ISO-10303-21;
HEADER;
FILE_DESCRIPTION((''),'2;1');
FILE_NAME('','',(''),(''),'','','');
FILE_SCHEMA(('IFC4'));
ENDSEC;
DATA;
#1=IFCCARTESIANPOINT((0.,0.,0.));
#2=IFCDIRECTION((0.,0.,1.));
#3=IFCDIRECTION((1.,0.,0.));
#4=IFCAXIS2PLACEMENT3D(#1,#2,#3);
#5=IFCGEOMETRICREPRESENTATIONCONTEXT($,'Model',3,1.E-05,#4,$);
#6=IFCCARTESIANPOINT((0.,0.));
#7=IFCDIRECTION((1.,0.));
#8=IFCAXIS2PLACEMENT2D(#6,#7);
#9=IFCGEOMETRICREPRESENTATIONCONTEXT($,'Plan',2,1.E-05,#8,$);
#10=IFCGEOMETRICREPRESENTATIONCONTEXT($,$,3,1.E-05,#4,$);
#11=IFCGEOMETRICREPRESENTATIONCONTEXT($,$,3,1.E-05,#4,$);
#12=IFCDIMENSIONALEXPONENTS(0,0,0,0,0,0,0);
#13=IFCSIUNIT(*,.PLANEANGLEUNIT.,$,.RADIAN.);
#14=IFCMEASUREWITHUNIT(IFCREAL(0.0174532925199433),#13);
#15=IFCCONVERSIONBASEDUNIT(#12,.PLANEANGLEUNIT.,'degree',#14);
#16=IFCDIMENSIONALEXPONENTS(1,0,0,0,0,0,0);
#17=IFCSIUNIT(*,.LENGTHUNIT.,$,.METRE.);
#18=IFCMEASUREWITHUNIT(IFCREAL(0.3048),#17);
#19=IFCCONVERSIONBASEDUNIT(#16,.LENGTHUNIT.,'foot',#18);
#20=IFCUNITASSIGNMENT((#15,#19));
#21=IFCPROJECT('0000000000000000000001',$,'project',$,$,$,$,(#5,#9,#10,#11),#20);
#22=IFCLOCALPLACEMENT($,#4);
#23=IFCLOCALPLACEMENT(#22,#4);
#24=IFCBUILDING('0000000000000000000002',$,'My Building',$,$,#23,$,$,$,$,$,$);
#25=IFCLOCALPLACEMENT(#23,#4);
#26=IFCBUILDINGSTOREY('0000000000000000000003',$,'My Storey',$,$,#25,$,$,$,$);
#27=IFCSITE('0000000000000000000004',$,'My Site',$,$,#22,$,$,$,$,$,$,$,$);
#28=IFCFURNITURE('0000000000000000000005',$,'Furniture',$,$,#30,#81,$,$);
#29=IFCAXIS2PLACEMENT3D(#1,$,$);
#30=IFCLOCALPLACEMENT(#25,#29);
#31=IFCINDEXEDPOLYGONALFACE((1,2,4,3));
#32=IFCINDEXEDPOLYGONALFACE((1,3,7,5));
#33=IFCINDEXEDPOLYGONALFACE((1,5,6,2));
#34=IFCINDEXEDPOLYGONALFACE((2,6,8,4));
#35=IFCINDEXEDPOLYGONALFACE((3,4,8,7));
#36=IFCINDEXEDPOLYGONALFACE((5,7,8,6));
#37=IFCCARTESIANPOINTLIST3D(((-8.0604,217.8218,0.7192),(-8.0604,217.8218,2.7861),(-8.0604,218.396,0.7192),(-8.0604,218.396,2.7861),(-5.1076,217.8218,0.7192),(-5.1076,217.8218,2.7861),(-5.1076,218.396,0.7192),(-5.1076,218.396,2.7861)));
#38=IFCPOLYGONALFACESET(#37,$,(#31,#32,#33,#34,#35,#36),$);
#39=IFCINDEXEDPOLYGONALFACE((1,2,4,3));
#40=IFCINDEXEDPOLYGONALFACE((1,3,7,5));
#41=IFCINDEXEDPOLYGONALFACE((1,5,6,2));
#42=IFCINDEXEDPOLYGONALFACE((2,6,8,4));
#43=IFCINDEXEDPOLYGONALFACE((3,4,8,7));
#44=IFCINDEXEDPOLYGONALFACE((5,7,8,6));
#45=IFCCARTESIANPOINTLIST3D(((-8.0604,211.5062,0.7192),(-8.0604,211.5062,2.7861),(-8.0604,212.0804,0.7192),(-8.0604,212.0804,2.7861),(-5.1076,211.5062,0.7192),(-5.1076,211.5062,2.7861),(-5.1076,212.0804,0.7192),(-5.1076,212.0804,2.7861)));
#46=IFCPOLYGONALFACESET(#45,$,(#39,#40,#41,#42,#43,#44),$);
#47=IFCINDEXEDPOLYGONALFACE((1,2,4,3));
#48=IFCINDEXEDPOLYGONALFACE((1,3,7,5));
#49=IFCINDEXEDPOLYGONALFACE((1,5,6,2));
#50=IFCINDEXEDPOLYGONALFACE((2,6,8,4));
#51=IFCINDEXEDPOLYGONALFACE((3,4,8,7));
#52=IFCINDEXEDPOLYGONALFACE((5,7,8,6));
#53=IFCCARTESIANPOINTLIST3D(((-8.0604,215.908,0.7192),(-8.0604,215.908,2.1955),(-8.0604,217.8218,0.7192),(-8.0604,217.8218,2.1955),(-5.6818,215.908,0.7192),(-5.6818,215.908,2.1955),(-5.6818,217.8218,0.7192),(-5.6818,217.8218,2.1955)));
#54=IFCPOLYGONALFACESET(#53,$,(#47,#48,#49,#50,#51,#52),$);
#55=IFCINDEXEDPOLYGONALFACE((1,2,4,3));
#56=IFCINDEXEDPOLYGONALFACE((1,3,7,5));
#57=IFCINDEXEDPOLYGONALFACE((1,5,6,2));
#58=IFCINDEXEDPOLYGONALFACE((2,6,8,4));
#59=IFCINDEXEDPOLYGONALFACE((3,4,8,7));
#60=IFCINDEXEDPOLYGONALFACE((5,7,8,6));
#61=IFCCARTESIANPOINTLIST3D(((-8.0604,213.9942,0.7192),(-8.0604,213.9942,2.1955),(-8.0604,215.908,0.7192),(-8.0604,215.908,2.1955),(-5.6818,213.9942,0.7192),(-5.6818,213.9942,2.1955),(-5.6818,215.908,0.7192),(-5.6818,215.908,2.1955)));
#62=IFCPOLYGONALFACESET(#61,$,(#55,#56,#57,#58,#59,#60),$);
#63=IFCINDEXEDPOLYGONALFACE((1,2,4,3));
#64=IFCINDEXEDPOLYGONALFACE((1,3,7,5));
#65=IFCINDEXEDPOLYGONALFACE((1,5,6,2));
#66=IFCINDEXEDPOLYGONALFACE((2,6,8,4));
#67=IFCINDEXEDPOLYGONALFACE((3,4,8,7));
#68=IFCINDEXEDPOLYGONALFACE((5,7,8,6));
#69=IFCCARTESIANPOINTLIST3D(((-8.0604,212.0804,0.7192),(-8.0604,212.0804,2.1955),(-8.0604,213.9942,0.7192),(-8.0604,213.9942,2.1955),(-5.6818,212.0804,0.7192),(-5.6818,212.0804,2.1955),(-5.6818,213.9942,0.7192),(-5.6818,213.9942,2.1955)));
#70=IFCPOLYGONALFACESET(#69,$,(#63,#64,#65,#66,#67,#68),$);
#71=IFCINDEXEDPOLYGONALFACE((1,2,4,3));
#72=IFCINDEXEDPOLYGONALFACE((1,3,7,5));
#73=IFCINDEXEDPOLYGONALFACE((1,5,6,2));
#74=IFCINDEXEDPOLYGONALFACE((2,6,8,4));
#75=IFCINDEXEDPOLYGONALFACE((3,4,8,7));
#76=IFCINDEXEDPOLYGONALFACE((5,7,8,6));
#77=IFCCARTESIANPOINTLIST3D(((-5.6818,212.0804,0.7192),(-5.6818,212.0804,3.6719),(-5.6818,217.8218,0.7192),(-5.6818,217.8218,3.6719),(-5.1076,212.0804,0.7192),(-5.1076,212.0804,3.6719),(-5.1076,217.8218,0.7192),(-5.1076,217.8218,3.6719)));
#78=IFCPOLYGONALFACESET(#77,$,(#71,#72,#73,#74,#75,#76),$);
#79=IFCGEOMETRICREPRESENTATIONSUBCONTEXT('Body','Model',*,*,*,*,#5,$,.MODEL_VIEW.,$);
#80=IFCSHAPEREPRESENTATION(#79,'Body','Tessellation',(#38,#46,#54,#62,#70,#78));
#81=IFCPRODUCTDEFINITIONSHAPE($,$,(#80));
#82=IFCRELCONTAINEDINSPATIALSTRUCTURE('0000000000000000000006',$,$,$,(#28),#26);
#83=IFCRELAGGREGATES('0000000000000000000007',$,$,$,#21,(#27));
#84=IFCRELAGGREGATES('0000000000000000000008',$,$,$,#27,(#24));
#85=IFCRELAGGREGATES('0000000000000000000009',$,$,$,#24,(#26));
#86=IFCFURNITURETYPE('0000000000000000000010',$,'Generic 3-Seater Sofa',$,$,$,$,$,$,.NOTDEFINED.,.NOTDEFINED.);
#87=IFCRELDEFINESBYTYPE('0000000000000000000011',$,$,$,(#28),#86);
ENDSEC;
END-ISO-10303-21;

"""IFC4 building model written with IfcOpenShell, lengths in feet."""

from ifc_helpers import new_model, entity, si_unit, converted_unit, frame, origin_with_axes, origin_2d_with_axis, place, context, subcontext, project, spatial, line, indexed_curve, outline, extrude, shape, source, transform, mapped, type_object, type_shapes, element, save


model = new_model("IFC4")

# Units and contexts
model_context = context("Model", 3, precision=1e-05, world=origin_with_axes())
plan_context = context("Plan", 2, precision=1e-05, world=origin_2d_with_axis())
context_of_model_1 = context(None, 3, precision=1e-05, world=origin_with_axes())
context_of_model_2 = context(None, 3, precision=1e-05, world=origin_with_axes())
body_context_1 = subcontext(model_context, "Body", "Model", "MODEL_VIEW")
body_context_2 = subcontext(plan_context, "Body", "Plan", "PLAN_VIEW")
ifc_project = project(units=[converted_unit("PLANEANGLEUNIT", "degree", entity("IfcReal", 0.0174532925199433), si_unit("PLANEANGLEUNIT", "RADIAN"), dimensions=[0, 0, 0, 0, 0, 0, 0]), converted_unit("LENGTHUNIT", "foot", entity("IfcReal", 0.3048), si_unit("LENGTHUNIT", "METRE"), dimensions=[1, 0, 0, 0, 0, 0, 0])], contexts=[model_context, plan_context, context_of_model_1, context_of_model_2])

# Site, building, storey
site_placement = place(None, origin_with_axes())
site = spatial("IfcSite", under=ifc_project, at=site_placement, Name="My Site")
building_placement = place(site_placement, origin_with_axes())
building = spatial("IfcBuilding", under=site, at=building_placement, Name="My Building")
storey_placement = place(building_placement, origin_with_axes())
storey = spatial("IfcBuildingStorey", under=building, at=storey_placement, Name="My Storey")

# Furniture
furniture_type = type_object("IfcFurnitureType", Name="Generic 3-Seater Sofa", AssemblyPlace="NOTDEFINED", PredefinedType="NOTDEFINED")
shared_shape_1 = source(origin_with_axes(), body_context_1, "Body", "SweptSolid", [
    extrude(outline(indexed_curve([(0.0, 0.0), (0.5741, 0.0), (0.5741, 2.9528), (0.0, 2.9528)], segments=[line(1, 2), line(2, 3), line(3, 4), line(4, 1)])), frame((-3.4449, -2.9528, 0.0), z_axis=(0.0, 0.0, 1.0), x_axis=(1.0, 0.0, 0.0)), (0.0, 0.0, 1.0), 2.0669),
    extrude(outline(indexed_curve([(0.0, 0.0), (0.5741, 0.0), (0.5741, 2.9528), (0.0, 2.9528)], segments=[line(1, 2), line(2, 3), line(3, 4), line(4, 1)])), frame((2.8707, -2.9528, 0.0), z_axis=(0.0, 0.0, 1.0), x_axis=(1.0, 0.0, 0.0)), (0.0, 0.0, 1.0), 2.0669),
    extrude(outline(indexed_curve([(0.5741, 0.0), (2.488, 0.0), (2.488, 2.3786), (0.5741, 2.3786)], segments=[line(1, 2), line(2, 3), line(3, 4), line(4, 1)])), frame((-3.4449, -2.9528, 0.0), z_axis=(0.0, 0.0, 1.0), x_axis=(1.0, 0.0, 0.0)), (0.0, 0.0, 1.0), 1.4764),
    extrude(outline(indexed_curve([(2.488, 0.0), (4.4018, 0.0), (4.4018, 2.3786), (2.488, 2.3786)], segments=[line(1, 2), line(2, 3), line(3, 4), line(4, 1)])), frame((-3.4449, -2.9528, 0.0), z_axis=(0.0, 0.0, 1.0), x_axis=(1.0, 0.0, 0.0)), (0.0, 0.0, 1.0), 1.4764),
    extrude(outline(indexed_curve([(4.4018, 0.0), (6.3156, 0.0), (6.3156, 2.3786), (4.4018, 2.3786)], segments=[line(1, 2), line(2, 3), line(3, 4), line(4, 1)])), frame((-3.4449, -2.9528, 0.0), z_axis=(0.0, 0.0, 1.0), x_axis=(1.0, 0.0, 0.0)), (0.0, 0.0, 1.0), 1.4764),
    extrude(outline(indexed_curve([(0.5741, 2.3786), (6.3156, 2.3786), (6.3156, 2.9528), (0.5741, 2.9528)], segments=[line(1, 2), line(2, 3), line(3, 4), line(4, 1)])), frame((-3.4449, -2.9528, 0.0), z_axis=(0.0, 0.0, 1.0), x_axis=(1.0, 0.0, 0.0)), (0.0, 0.0, 1.0), 2.9528),
])
shared_shape_2 = source(origin_with_axes(), body_context_2, "Body", "Annotation2D", [
    entity("IfcAnnotationFillArea", entity("IfcIndexedPolyCurve", entity("IfcCartesianPointList2D", [[-3.4449, -2.9528], [-2.8707, -2.9528], [-2.8707, 0.0], [-3.4449, 0.0], [2.8707, -2.9528], [3.4449, -2.9528], [3.4449, 0.0], [2.8707, 0.0], [-2.8707, -2.9528], [-0.9569, -2.9528], [-0.9569, -2.9528], [-0.9569, -0.5741], [-2.8707, -0.5741], [-0.9569, -2.9528], [0.9569, -2.9528], [0.9569, -2.9528], [0.9569, -0.5741], [-0.9569, -0.5741], [-0.9569, -0.5741], [0.9569, -2.9528], [2.8707, -2.9528], [2.8707, -0.5741], [0.9569, -0.5741], [-2.8707, -0.5741], [2.8707, -0.5741], [2.8707, 0.0], [-2.8707, 0.0], [0.9569, -0.5741]]), [entity("IfcLineIndex", [5, 8]), entity("IfcLineIndex", [8, 7]), entity("IfcLineIndex", [7, 6]), entity("IfcLineIndex", [6, 5])])),
    entity("IfcAnnotationFillArea", entity("IfcIndexedPolyCurve", entity("IfcCartesianPointList2D", [[-3.4449, -2.9528], [-2.8707, -2.9528], [-2.8707, 0.0], [-3.4449, 0.0], [2.8707, -2.9528], [3.4449, -2.9528], [3.4449, 0.0], [2.8707, 0.0], [-2.8707, -2.9528], [-0.9569, -2.9528], [-0.9569, -2.9528], [-0.9569, -0.5741], [-2.8707, -0.5741], [-0.9569, -2.9528], [0.9569, -2.9528], [0.9569, -2.9528], [0.9569, -0.5741], [-0.9569, -0.5741], [-0.9569, -0.5741], [0.9569, -2.9528], [2.8707, -2.9528], [2.8707, -0.5741], [0.9569, -0.5741], [-2.8707, -0.5741], [2.8707, -0.5741], [2.8707, 0.0], [-2.8707, 0.0], [0.9569, -0.5741]]), [entity("IfcLineIndex", [20, 23]), entity("IfcLineIndex", [23, 22]), entity("IfcLineIndex", [22, 21]), entity("IfcLineIndex", [21, 20])])),
    entity("IfcAnnotationFillArea", entity("IfcIndexedPolyCurve", entity("IfcCartesianPointList2D", [[-3.4449, -2.9528], [-2.8707, -2.9528], [-2.8707, 0.0], [-3.4449, 0.0], [2.8707, -2.9528], [3.4449, -2.9528], [3.4449, 0.0], [2.8707, 0.0], [-2.8707, -2.9528], [-0.9569, -2.9528], [-0.9569, -2.9528], [-0.9569, -0.5741], [-2.8707, -0.5741], [-0.9569, -2.9528], [0.9569, -2.9528], [0.9569, -2.9528], [0.9569, -0.5741], [-0.9569, -0.5741], [-0.9569, -0.5741], [0.9569, -2.9528], [2.8707, -2.9528], [2.8707, -0.5741], [0.9569, -0.5741], [-2.8707, -0.5741], [2.8707, -0.5741], [2.8707, 0.0], [-2.8707, 0.0], [0.9569, -0.5741]]), [entity("IfcLineIndex", [1, 4]), entity("IfcLineIndex", [4, 3]), entity("IfcLineIndex", [3, 2]), entity("IfcLineIndex", [2, 1])])),
    entity("IfcAnnotationFillArea", entity("IfcIndexedPolyCurve", entity("IfcCartesianPointList2D", [[-3.4449, -2.9528], [-2.8707, -2.9528], [-2.8707, 0.0], [-3.4449, 0.0], [2.8707, -2.9528], [3.4449, -2.9528], [3.4449, 0.0], [2.8707, 0.0], [-2.8707, -2.9528], [-0.9569, -2.9528], [-0.9569, -2.9528], [-0.9569, -0.5741], [-2.8707, -0.5741], [-0.9569, -2.9528], [0.9569, -2.9528], [0.9569, -2.9528], [0.9569, -0.5741], [-0.9569, -0.5741], [-0.9569, -0.5741], [0.9569, -2.9528], [2.8707, -2.9528], [2.8707, -0.5741], [0.9569, -0.5741], [-2.8707, -0.5741], [2.8707, -0.5741], [2.8707, 0.0], [-2.8707, 0.0], [0.9569, -0.5741]]), [entity("IfcLineIndex", [9, 13]), entity("IfcLineIndex", [13, 12]), entity("IfcLineIndex", [12, 11]), entity("IfcLineIndex", [11, 10]), entity("IfcLineIndex", [10, 9])])),
    entity("IfcAnnotationFillArea", entity("IfcIndexedPolyCurve", entity("IfcCartesianPointList2D", [[-3.4449, -2.9528], [-2.8707, -2.9528], [-2.8707, 0.0], [-3.4449, 0.0], [2.8707, -2.9528], [3.4449, -2.9528], [3.4449, 0.0], [2.8707, 0.0], [-2.8707, -2.9528], [-0.9569, -2.9528], [-0.9569, -2.9528], [-0.9569, -0.5741], [-2.8707, -0.5741], [-0.9569, -2.9528], [0.9569, -2.9528], [0.9569, -2.9528], [0.9569, -0.5741], [-0.9569, -0.5741], [-0.9569, -0.5741], [0.9569, -2.9528], [2.8707, -2.9528], [2.8707, -0.5741], [0.9569, -0.5741], [-2.8707, -0.5741], [2.8707, -0.5741], [2.8707, 0.0], [-2.8707, 0.0], [0.9569, -0.5741]]), [entity("IfcLineIndex", [14, 19]), entity("IfcLineIndex", [19, 28]), entity("IfcLineIndex", [28, 15]), entity("IfcLineIndex", [15, 14])])),
    entity("IfcAnnotationFillArea", entity("IfcIndexedPolyCurve", entity("IfcCartesianPointList2D", [[-3.4449, -2.9528], [-2.8707, -2.9528], [-2.8707, 0.0], [-3.4449, 0.0], [2.8707, -2.9528], [3.4449, -2.9528], [3.4449, 0.0], [2.8707, 0.0], [-2.8707, -2.9528], [-0.9569, -2.9528], [-0.9569, -2.9528], [-0.9569, -0.5741], [-2.8707, -0.5741], [-0.9569, -2.9528], [0.9569, -2.9528], [0.9569, -2.9528], [0.9569, -0.5741], [-0.9569, -0.5741], [-0.9569, -0.5741], [0.9569, -2.9528], [2.8707, -2.9528], [2.8707, -0.5741], [0.9569, -0.5741], [-2.8707, -0.5741], [2.8707, -0.5741], [2.8707, 0.0], [-2.8707, 0.0], [0.9569, -0.5741]]), [entity("IfcLineIndex", [24, 27]), entity("IfcLineIndex", [27, 26]), entity("IfcLineIndex", [26, 25]), entity("IfcLineIndex", [25, 24])])),
])
type_shapes(furniture_type, [shared_shape_1, shared_shape_2])
furniture_placement = place(storey_placement, frame((-5.1076, 214.9511, 0.7192), z_axis=(0.0, 0.0, 1.0), x_axis=(0.0, -1.0, 0.0)))
element("IfcFurniture", 1, at=furniture_placement, inside=storey, type_object=furniture_type, Name="Furniture", shapes=[
    shape(body_context_1, "Body", "MappedRepresentation", [mapped(shared_shape_1, transform((0.0, 0.0, 0.0), x_axis=(1.0, 0.0, 0.0), y_axis=(0.0, 1.0, 0.0), z_axis=(0.0, 0.0, 1.0), scale=1.0))]),
    shape(body_context_2, "Body", "MappedRepresentation", [mapped(shared_shape_2, transform((0.0, 0.0, 0.0), x_axis=(1.0, 0.0, 0.0), y_axis=(0.0, 1.0, 0.0), z_axis=(0.0, 0.0, 1.0), scale=1.0))]),
])

save(model, "model.ifc")
